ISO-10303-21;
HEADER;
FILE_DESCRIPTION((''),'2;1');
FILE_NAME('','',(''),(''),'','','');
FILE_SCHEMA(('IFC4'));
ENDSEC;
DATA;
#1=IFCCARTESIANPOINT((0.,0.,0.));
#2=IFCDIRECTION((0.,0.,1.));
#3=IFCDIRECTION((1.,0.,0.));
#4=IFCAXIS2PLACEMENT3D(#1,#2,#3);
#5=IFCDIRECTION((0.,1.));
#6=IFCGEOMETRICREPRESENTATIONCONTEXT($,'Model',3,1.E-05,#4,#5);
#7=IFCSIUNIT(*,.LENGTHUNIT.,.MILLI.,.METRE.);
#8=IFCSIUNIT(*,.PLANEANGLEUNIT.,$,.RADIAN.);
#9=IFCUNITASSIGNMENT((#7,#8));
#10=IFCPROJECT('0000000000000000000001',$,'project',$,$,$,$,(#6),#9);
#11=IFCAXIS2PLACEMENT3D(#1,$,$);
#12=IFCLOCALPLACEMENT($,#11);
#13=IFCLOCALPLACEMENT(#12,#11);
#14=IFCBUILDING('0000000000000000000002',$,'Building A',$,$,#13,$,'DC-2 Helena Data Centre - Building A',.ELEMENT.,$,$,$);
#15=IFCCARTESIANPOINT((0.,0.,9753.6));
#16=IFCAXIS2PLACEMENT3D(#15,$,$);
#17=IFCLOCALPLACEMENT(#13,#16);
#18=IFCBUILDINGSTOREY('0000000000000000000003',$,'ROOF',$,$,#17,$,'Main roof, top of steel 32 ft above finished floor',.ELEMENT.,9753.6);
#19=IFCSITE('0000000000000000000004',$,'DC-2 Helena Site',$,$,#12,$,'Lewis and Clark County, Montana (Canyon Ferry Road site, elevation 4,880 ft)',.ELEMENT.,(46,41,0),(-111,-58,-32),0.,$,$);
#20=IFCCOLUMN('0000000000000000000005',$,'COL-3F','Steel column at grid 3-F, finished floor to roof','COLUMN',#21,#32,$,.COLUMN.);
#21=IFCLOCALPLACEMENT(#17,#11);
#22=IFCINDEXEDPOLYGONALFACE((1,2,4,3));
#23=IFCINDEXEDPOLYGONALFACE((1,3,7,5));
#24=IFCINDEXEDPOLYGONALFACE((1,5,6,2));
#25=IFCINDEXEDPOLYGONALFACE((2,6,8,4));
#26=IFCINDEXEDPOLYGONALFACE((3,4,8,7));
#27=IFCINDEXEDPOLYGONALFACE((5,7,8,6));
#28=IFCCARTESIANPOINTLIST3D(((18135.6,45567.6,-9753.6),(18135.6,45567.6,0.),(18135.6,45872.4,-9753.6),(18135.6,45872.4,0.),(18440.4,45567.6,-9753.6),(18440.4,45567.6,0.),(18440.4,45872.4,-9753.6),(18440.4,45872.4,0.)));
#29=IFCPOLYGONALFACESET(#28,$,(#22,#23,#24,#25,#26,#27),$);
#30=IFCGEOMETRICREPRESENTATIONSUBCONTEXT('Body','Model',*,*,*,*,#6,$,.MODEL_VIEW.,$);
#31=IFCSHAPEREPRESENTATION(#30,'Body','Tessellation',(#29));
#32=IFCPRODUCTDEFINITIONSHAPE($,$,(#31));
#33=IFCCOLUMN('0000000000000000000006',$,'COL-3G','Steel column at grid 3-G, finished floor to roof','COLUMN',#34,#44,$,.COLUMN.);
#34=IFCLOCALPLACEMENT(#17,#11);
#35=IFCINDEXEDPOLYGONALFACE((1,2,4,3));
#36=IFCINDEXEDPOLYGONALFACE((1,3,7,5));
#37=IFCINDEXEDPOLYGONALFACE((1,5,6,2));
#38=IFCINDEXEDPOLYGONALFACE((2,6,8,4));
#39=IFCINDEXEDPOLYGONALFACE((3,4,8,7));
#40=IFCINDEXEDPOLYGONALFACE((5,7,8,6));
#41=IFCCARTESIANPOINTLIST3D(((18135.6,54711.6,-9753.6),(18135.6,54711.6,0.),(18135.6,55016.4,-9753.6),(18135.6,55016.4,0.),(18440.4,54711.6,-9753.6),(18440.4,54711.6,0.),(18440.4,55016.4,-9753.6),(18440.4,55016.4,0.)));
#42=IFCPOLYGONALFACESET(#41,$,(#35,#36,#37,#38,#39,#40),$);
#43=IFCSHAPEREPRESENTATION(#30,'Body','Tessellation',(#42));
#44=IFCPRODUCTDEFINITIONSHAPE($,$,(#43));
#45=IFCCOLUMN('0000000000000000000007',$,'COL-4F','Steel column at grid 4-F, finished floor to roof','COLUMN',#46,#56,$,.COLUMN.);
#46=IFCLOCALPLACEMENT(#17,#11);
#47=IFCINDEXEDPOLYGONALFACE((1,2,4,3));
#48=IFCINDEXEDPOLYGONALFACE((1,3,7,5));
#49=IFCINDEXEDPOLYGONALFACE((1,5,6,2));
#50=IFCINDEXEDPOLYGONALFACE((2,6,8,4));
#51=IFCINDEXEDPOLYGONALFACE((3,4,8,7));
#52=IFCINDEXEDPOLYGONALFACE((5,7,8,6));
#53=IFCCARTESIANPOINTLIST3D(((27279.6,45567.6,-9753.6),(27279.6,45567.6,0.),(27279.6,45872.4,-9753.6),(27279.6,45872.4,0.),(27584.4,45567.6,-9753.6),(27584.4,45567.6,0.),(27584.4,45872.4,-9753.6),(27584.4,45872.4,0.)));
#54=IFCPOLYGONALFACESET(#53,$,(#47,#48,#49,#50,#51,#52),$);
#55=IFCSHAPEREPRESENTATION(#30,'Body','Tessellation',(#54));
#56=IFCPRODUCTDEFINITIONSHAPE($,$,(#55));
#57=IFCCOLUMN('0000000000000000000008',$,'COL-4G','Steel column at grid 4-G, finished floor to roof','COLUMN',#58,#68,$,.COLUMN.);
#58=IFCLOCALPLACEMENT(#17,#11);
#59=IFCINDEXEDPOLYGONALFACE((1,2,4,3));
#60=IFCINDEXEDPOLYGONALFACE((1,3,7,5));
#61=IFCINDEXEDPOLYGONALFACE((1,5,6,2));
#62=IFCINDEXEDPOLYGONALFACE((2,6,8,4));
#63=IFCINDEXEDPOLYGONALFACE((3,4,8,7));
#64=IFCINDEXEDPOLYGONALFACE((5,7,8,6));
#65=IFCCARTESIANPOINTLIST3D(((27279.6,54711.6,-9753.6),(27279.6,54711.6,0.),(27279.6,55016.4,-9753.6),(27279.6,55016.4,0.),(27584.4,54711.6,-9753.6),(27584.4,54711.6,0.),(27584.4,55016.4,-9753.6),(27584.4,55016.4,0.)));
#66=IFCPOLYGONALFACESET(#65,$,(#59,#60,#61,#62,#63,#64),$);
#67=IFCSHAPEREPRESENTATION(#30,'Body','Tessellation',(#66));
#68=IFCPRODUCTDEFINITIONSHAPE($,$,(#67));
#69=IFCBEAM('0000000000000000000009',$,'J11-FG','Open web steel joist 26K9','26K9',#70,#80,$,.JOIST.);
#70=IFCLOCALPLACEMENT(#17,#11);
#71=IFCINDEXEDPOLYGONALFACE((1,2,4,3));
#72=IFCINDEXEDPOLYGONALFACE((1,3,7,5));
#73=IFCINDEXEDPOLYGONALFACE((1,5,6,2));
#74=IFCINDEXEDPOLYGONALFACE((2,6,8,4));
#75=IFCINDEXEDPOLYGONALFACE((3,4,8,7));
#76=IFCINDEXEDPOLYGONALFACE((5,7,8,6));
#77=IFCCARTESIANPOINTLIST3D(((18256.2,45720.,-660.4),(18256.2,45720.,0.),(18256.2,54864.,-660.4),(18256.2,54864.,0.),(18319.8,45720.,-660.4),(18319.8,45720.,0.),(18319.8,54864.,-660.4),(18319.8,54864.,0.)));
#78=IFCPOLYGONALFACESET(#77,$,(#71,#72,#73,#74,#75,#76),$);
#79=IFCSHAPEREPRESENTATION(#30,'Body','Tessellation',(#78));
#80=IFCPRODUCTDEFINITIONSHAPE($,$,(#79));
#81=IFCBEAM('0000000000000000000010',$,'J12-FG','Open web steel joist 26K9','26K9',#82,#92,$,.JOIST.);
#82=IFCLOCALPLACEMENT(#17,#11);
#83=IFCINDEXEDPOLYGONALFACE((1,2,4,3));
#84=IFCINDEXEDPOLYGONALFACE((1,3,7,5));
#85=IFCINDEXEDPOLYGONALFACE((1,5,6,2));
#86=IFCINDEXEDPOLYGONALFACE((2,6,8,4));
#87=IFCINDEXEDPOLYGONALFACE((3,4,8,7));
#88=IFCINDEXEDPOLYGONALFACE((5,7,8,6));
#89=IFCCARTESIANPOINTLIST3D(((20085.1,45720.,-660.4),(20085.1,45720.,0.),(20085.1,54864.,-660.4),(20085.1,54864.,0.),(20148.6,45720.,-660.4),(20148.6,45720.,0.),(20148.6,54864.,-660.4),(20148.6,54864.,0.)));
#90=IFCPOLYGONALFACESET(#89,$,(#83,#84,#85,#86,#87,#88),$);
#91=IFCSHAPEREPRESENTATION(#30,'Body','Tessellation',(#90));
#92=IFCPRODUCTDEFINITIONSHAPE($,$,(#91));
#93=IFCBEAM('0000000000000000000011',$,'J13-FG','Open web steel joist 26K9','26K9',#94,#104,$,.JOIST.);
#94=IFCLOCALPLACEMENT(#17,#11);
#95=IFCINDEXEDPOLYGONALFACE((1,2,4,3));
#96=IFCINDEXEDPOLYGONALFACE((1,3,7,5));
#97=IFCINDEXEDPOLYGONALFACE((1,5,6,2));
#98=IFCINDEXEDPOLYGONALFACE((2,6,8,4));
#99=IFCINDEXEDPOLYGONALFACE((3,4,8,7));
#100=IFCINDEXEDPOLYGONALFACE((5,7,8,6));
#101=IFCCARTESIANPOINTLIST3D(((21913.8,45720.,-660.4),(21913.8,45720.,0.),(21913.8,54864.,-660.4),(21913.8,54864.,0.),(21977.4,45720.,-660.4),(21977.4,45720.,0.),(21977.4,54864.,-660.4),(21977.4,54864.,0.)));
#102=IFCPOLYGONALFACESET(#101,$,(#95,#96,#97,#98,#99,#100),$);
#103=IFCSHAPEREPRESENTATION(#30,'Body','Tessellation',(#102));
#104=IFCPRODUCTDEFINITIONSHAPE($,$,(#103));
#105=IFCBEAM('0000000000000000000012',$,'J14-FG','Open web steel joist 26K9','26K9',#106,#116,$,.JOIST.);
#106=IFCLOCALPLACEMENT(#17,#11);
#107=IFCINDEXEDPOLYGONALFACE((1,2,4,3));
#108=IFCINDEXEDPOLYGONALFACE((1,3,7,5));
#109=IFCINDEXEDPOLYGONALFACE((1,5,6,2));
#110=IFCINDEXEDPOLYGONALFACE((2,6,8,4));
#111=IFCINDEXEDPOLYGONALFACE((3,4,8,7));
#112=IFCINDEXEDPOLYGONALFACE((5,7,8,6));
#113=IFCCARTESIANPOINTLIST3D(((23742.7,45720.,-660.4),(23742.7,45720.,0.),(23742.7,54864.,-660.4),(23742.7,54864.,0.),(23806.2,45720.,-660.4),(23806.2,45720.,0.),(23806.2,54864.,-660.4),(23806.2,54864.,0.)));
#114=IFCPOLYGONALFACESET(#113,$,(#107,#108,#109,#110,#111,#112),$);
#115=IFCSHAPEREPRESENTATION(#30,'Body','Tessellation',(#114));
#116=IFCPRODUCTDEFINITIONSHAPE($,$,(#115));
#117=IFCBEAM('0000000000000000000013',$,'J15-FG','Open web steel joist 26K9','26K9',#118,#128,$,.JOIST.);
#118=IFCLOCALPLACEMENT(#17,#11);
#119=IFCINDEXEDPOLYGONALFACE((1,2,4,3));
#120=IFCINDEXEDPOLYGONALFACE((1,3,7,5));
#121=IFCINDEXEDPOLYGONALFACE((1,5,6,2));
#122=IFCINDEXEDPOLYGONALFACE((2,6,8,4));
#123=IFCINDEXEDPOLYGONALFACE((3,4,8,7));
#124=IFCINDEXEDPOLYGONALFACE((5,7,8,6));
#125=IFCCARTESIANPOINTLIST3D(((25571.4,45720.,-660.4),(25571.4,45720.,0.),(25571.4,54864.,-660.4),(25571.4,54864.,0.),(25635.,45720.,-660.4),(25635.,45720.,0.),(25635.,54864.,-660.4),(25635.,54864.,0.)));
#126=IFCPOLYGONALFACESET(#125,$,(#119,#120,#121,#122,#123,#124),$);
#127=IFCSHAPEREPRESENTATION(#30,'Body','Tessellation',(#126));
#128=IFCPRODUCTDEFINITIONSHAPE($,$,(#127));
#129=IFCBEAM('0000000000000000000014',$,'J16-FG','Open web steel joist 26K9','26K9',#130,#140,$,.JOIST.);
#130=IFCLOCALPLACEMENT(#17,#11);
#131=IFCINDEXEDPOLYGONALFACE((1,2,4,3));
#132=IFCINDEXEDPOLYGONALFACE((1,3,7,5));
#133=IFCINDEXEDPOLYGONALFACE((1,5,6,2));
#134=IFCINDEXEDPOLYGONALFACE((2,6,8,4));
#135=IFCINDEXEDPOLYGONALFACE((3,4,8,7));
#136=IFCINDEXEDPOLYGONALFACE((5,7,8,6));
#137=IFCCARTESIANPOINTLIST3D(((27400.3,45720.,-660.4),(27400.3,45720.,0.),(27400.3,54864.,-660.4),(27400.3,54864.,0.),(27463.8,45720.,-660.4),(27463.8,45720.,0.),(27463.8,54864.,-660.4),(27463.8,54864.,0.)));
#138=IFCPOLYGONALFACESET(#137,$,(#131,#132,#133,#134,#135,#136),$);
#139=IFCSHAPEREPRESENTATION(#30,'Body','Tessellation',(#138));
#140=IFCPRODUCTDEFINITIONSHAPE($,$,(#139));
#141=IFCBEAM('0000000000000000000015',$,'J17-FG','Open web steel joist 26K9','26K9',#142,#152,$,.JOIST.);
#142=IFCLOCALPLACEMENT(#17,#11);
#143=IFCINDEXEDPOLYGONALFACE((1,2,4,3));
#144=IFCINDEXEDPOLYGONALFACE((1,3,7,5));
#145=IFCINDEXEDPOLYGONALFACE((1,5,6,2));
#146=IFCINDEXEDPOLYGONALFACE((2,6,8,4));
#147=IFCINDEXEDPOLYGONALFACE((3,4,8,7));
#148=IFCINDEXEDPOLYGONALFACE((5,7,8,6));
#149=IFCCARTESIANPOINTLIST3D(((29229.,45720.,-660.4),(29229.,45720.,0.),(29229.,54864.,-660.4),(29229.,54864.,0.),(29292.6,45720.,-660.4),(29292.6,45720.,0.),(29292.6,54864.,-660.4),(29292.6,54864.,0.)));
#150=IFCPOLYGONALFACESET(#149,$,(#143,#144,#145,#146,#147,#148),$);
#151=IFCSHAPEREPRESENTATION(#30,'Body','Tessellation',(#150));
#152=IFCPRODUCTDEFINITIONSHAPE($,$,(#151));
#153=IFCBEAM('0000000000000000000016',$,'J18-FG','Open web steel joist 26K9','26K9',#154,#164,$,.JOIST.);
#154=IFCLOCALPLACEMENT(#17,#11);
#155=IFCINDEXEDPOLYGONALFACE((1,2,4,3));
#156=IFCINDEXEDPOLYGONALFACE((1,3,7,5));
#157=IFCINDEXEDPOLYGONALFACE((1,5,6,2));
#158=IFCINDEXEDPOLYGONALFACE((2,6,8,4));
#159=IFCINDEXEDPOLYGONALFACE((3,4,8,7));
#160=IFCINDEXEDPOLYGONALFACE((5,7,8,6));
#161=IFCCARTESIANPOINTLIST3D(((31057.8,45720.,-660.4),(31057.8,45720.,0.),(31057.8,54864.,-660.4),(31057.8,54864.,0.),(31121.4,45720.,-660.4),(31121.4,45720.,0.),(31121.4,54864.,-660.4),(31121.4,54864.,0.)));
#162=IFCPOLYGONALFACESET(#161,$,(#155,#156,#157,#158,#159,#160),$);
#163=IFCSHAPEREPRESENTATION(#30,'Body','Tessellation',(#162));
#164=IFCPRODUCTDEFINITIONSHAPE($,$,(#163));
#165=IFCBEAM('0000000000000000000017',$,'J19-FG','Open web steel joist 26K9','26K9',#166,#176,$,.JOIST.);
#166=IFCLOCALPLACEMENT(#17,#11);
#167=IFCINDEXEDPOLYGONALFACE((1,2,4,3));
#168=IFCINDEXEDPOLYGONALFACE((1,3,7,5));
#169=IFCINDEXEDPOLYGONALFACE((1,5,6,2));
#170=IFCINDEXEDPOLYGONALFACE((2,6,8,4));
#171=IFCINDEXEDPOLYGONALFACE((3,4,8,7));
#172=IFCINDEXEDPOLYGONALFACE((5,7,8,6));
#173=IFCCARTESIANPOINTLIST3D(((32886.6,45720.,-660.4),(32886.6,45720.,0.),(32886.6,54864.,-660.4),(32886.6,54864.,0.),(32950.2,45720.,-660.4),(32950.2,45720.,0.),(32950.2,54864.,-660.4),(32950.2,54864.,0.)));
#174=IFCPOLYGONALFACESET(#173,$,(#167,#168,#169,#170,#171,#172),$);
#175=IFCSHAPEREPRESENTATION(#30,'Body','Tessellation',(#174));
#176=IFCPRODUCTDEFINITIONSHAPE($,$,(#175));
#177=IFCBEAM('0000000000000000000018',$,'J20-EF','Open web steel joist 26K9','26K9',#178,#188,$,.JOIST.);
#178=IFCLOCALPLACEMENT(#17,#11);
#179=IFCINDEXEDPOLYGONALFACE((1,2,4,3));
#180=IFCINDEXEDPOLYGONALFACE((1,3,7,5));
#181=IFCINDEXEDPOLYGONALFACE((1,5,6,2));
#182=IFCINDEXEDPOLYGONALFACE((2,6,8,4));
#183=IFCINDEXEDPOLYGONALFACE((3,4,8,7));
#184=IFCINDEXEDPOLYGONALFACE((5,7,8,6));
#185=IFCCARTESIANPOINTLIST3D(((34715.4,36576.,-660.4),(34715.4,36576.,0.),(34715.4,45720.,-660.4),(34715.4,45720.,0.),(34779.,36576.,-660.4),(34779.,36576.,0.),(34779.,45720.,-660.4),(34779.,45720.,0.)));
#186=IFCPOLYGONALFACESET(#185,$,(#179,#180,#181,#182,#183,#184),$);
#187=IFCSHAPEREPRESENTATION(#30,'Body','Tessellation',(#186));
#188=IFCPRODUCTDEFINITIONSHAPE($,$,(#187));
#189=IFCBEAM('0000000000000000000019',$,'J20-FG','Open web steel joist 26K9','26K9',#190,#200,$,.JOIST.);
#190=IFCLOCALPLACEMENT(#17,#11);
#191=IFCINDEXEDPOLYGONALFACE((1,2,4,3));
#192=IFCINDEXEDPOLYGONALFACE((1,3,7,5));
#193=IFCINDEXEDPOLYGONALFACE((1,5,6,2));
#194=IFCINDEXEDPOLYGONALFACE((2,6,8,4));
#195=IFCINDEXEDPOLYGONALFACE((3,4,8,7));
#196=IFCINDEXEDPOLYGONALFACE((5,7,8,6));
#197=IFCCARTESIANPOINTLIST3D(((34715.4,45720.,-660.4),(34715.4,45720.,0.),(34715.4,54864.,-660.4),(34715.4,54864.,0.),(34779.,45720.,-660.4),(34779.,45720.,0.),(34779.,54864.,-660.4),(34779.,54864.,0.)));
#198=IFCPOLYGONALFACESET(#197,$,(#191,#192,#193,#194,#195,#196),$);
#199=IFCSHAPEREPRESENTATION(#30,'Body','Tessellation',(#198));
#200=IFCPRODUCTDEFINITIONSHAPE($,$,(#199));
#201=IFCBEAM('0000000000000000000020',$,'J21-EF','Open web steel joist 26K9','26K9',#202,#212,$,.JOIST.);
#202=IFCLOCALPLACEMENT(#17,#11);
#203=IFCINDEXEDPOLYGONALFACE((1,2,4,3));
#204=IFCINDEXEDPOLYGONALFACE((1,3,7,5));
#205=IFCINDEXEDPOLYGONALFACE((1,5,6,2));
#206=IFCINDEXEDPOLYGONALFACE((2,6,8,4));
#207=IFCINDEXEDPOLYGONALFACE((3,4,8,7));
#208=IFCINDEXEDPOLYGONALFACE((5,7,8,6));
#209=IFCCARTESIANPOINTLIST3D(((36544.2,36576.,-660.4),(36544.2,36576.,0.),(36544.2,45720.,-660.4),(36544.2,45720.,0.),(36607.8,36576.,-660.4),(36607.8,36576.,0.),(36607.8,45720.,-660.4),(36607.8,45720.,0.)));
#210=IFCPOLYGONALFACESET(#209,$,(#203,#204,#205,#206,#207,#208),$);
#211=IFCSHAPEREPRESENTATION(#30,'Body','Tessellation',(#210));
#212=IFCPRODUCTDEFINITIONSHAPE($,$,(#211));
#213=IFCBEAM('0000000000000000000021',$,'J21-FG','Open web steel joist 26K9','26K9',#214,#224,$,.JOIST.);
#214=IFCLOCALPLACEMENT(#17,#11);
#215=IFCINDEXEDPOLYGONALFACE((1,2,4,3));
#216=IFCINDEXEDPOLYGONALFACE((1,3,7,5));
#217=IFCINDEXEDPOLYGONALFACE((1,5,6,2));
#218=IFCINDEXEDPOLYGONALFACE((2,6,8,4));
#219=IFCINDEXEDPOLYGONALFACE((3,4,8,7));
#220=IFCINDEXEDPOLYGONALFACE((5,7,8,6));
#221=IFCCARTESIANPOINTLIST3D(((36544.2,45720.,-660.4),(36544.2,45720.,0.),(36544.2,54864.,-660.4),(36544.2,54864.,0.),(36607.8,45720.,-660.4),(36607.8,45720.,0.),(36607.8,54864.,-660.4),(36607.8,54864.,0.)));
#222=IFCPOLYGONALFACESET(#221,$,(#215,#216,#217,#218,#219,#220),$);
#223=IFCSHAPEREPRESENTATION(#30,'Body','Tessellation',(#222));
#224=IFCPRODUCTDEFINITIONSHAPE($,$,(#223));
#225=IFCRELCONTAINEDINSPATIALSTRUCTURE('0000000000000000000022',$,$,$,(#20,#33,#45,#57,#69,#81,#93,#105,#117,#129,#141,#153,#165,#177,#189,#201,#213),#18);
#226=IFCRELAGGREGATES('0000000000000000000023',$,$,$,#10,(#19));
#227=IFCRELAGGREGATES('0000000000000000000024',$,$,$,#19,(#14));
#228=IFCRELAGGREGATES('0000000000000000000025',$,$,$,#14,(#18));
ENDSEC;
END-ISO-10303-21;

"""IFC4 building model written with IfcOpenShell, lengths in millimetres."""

from ifc_helpers import new_model, si_unit, direction, frame, origin, origin_with_axes, origin_2d, place, context, subcontext, project, spatial, rectangle, extrude, element, save


model = new_model("IFC4")

# Units and contexts
model_context = context("Model", 3, precision=1e-05, world=origin_with_axes(), true_north=direction((0.0, 1.0)))
body_context = subcontext(model_context, "Body", "Model", "MODEL_VIEW")
ifc_project = project(units=[si_unit("LENGTHUNIT", "METRE", prefix="MILLI"), si_unit("PLANEANGLEUNIT", "RADIAN")], contexts=[model_context])

# Site, building, storey
site_placement = place(None, origin())
site = spatial("IfcSite", under=ifc_project, at=site_placement, Name="DC-2 Helena Site", LongName="Lewis and Clark County, Montana (Canyon Ferry Road site, elevation 4,880 ft)", CompositionType="ELEMENT", RefLatitude=(46, 41, 0), RefLongitude=(-111, -58, -32), RefElevation=0.0)
building_placement = place(site_placement, origin())
building = spatial("IfcBuilding", under=site, at=building_placement, Name="Building A", LongName="DC-2 Helena Data Centre - Building A", CompositionType="ELEMENT")
storey_placement = place(building_placement, frame((0.0, 0.0, 9753.6)))
storey = spatial("IfcBuildingStorey", under=building, at=storey_placement, Name="ROOF", LongName="Main roof, top of steel 32 ft above finished floor", CompositionType="ELEMENT", Elevation=9753.6)

# Columns
column_1_placement = place(storey_placement, frame((18288.0, 45720.0, -9753.6)))
element("IfcColumn", 1, at=column_1_placement, inside=storey, Name="COL-3F", Description="Steel column at grid 3-F, finished floor to roof", ObjectType="COLUMN", PredefinedType="COLUMN", context=body_context, shape_type="SweptSolid", body=[
    extrude(rectangle(XDim=304.8, YDim=304.8, at=origin_2d()), origin(), (0.0, 0.0, 1.0), 9753.6),
])
placement_1 = place(storey_placement, frame((18288.0, 54864.0, -9753.6)))
element("IfcColumn", 2, at=placement_1, inside=storey, Name="COL-3G", Description="Steel column at grid 3-G, finished floor to roof", ObjectType="COLUMN", PredefinedType="COLUMN", context=body_context, shape_type="SweptSolid", body=[
    extrude(rectangle(XDim=304.8, YDim=304.8, at=origin_2d()), origin(), (0.0, 0.0, 1.0), 9753.6),
])
column_2_placement = place(storey_placement, frame((27432.0, 45720.0, -9753.6)))
element("IfcColumn", 3, at=column_2_placement, inside=storey, Name="COL-4F", Description="Steel column at grid 4-F, finished floor to roof", ObjectType="COLUMN", PredefinedType="COLUMN", context=body_context, shape_type="SweptSolid", body=[
    extrude(rectangle(XDim=304.8, YDim=304.8, at=origin_2d()), origin(), (0.0, 0.0, 1.0), 9753.6),
])
placement_2 = place(storey_placement, frame((27432.0, 54864.0, -9753.6)))
element("IfcColumn", 4, at=placement_2, inside=storey, Name="COL-4G", Description="Steel column at grid 4-G, finished floor to roof", ObjectType="COLUMN", PredefinedType="COLUMN", context=body_context, shape_type="SweptSolid", body=[
    extrude(rectangle(XDim=304.8, YDim=304.8, at=origin_2d()), origin(), (0.0, 0.0, 1.0), 9753.6),
])

# Beams
placement_3 = place(storey_placement, frame((18288.0, 45720.0, 0.0)))
element("IfcBeam", 5, at=placement_3, inside=storey, Name="J11-FG", Description="Open web steel joist 26K9", ObjectType="26K9", PredefinedType="JOIST", context=body_context, shape_type="SweptSolid", body=[
    extrude(rectangle(XDim=63.5, YDim=660.4, at=origin_2d()), frame((0.0, 0.0, -330.2), z_axis=(0.0, 1.0, 0.0), x_axis=(1.0, 0.0, 0.0)), (0.0, 0.0, 1.0), 9144.0),
])
for number, where, name in (
    (6, (20116.8, 45720.0, 0.0), "J12-FG"),
    (7, (21945.6, 45720.0, 0.0), "J13-FG"),
    (8, (23774.4, 45720.0, 0.0), "J14-FG"),
    (9, (25603.2, 45720.0, 0.0), "J15-FG"),
):
    element("IfcBeam", number, at=place(storey_placement, frame(where)), inside=storey, Name=name, Description="Open web steel joist 26K9", ObjectType="26K9", PredefinedType="JOIST", context=body_context, shape_type="SweptSolid", body=[
        extrude(rectangle(XDim=63.5, YDim=660.4, at=origin_2d()), frame((0.0, 0.0, -330.2), z_axis=(0.0, 1.0, 0.0), x_axis=(1.0, 0.0, 0.0)), (0.0, 0.0, 1.0), 9144.0),
    ])
placement_4 = place(storey_placement, frame((27432.0, 45720.0, 0.0)))
element("IfcBeam", 10, at=placement_4, inside=storey, Name="J16-FG", Description="Open web steel joist 26K9", ObjectType="26K9", PredefinedType="JOIST", context=body_context, shape_type="SweptSolid", body=[
    extrude(rectangle(XDim=63.5, YDim=660.4, at=origin_2d()), frame((0.0, 0.0, -330.2), z_axis=(0.0, 1.0, 0.0), x_axis=(1.0, 0.0, 0.0)), (0.0, 0.0, 1.0), 9144.0),
])
for number, where, name in (
    (11, (29260.8, 45720.0, 0.0), "J17-FG"),
    (12, (31089.6, 45720.0, 0.0), "J18-FG"),
    (13, (32918.4, 45720.0, 0.0), "J19-FG"),
    (14, (34747.2, 36576.0, 0.0), "J20-EF"),
    (15, (34747.2, 45720.0, 0.0), "J20-FG"),
):
    element("IfcBeam", number, at=place(storey_placement, frame(where)), inside=storey, Name=name, Description="Open web steel joist 26K9", ObjectType="26K9", PredefinedType="JOIST", context=body_context, shape_type="SweptSolid", body=[
        extrude(rectangle(XDim=63.5, YDim=660.4, at=origin_2d()), frame((0.0, 0.0, -330.2), z_axis=(0.0, 1.0, 0.0), x_axis=(1.0, 0.0, 0.0)), (0.0, 0.0, 1.0), 9144.0),
    ])
beam_1_placement = place(storey_placement, frame((36576.0, 36576.0, 0.0)))
element("IfcBeam", 16, at=beam_1_placement, inside=storey, Name="J21-EF", Description="Open web steel joist 26K9", ObjectType="26K9", PredefinedType="JOIST", context=body_context, shape_type="SweptSolid", body=[
    extrude(rectangle(XDim=63.5, YDim=660.4, at=origin_2d()), frame((0.0, 0.0, -330.2), z_axis=(0.0, 1.0, 0.0), x_axis=(1.0, 0.0, 0.0)), (0.0, 0.0, 1.0), 9144.0),
])
beam_2_placement = place(storey_placement, frame((36576.0, 45720.0, 0.0)))
element("IfcBeam", 17, at=beam_2_placement, inside=storey, Name="J21-FG", Description="Open web steel joist 26K9", ObjectType="26K9", PredefinedType="JOIST", context=body_context, shape_type="SweptSolid", body=[
    extrude(rectangle(XDim=63.5, YDim=660.4, at=origin_2d()), frame((0.0, 0.0, -330.2), z_axis=(0.0, 1.0, 0.0), x_axis=(1.0, 0.0, 0.0)), (0.0, 0.0, 1.0), 9144.0),
])

save(model, "model.ifc")
